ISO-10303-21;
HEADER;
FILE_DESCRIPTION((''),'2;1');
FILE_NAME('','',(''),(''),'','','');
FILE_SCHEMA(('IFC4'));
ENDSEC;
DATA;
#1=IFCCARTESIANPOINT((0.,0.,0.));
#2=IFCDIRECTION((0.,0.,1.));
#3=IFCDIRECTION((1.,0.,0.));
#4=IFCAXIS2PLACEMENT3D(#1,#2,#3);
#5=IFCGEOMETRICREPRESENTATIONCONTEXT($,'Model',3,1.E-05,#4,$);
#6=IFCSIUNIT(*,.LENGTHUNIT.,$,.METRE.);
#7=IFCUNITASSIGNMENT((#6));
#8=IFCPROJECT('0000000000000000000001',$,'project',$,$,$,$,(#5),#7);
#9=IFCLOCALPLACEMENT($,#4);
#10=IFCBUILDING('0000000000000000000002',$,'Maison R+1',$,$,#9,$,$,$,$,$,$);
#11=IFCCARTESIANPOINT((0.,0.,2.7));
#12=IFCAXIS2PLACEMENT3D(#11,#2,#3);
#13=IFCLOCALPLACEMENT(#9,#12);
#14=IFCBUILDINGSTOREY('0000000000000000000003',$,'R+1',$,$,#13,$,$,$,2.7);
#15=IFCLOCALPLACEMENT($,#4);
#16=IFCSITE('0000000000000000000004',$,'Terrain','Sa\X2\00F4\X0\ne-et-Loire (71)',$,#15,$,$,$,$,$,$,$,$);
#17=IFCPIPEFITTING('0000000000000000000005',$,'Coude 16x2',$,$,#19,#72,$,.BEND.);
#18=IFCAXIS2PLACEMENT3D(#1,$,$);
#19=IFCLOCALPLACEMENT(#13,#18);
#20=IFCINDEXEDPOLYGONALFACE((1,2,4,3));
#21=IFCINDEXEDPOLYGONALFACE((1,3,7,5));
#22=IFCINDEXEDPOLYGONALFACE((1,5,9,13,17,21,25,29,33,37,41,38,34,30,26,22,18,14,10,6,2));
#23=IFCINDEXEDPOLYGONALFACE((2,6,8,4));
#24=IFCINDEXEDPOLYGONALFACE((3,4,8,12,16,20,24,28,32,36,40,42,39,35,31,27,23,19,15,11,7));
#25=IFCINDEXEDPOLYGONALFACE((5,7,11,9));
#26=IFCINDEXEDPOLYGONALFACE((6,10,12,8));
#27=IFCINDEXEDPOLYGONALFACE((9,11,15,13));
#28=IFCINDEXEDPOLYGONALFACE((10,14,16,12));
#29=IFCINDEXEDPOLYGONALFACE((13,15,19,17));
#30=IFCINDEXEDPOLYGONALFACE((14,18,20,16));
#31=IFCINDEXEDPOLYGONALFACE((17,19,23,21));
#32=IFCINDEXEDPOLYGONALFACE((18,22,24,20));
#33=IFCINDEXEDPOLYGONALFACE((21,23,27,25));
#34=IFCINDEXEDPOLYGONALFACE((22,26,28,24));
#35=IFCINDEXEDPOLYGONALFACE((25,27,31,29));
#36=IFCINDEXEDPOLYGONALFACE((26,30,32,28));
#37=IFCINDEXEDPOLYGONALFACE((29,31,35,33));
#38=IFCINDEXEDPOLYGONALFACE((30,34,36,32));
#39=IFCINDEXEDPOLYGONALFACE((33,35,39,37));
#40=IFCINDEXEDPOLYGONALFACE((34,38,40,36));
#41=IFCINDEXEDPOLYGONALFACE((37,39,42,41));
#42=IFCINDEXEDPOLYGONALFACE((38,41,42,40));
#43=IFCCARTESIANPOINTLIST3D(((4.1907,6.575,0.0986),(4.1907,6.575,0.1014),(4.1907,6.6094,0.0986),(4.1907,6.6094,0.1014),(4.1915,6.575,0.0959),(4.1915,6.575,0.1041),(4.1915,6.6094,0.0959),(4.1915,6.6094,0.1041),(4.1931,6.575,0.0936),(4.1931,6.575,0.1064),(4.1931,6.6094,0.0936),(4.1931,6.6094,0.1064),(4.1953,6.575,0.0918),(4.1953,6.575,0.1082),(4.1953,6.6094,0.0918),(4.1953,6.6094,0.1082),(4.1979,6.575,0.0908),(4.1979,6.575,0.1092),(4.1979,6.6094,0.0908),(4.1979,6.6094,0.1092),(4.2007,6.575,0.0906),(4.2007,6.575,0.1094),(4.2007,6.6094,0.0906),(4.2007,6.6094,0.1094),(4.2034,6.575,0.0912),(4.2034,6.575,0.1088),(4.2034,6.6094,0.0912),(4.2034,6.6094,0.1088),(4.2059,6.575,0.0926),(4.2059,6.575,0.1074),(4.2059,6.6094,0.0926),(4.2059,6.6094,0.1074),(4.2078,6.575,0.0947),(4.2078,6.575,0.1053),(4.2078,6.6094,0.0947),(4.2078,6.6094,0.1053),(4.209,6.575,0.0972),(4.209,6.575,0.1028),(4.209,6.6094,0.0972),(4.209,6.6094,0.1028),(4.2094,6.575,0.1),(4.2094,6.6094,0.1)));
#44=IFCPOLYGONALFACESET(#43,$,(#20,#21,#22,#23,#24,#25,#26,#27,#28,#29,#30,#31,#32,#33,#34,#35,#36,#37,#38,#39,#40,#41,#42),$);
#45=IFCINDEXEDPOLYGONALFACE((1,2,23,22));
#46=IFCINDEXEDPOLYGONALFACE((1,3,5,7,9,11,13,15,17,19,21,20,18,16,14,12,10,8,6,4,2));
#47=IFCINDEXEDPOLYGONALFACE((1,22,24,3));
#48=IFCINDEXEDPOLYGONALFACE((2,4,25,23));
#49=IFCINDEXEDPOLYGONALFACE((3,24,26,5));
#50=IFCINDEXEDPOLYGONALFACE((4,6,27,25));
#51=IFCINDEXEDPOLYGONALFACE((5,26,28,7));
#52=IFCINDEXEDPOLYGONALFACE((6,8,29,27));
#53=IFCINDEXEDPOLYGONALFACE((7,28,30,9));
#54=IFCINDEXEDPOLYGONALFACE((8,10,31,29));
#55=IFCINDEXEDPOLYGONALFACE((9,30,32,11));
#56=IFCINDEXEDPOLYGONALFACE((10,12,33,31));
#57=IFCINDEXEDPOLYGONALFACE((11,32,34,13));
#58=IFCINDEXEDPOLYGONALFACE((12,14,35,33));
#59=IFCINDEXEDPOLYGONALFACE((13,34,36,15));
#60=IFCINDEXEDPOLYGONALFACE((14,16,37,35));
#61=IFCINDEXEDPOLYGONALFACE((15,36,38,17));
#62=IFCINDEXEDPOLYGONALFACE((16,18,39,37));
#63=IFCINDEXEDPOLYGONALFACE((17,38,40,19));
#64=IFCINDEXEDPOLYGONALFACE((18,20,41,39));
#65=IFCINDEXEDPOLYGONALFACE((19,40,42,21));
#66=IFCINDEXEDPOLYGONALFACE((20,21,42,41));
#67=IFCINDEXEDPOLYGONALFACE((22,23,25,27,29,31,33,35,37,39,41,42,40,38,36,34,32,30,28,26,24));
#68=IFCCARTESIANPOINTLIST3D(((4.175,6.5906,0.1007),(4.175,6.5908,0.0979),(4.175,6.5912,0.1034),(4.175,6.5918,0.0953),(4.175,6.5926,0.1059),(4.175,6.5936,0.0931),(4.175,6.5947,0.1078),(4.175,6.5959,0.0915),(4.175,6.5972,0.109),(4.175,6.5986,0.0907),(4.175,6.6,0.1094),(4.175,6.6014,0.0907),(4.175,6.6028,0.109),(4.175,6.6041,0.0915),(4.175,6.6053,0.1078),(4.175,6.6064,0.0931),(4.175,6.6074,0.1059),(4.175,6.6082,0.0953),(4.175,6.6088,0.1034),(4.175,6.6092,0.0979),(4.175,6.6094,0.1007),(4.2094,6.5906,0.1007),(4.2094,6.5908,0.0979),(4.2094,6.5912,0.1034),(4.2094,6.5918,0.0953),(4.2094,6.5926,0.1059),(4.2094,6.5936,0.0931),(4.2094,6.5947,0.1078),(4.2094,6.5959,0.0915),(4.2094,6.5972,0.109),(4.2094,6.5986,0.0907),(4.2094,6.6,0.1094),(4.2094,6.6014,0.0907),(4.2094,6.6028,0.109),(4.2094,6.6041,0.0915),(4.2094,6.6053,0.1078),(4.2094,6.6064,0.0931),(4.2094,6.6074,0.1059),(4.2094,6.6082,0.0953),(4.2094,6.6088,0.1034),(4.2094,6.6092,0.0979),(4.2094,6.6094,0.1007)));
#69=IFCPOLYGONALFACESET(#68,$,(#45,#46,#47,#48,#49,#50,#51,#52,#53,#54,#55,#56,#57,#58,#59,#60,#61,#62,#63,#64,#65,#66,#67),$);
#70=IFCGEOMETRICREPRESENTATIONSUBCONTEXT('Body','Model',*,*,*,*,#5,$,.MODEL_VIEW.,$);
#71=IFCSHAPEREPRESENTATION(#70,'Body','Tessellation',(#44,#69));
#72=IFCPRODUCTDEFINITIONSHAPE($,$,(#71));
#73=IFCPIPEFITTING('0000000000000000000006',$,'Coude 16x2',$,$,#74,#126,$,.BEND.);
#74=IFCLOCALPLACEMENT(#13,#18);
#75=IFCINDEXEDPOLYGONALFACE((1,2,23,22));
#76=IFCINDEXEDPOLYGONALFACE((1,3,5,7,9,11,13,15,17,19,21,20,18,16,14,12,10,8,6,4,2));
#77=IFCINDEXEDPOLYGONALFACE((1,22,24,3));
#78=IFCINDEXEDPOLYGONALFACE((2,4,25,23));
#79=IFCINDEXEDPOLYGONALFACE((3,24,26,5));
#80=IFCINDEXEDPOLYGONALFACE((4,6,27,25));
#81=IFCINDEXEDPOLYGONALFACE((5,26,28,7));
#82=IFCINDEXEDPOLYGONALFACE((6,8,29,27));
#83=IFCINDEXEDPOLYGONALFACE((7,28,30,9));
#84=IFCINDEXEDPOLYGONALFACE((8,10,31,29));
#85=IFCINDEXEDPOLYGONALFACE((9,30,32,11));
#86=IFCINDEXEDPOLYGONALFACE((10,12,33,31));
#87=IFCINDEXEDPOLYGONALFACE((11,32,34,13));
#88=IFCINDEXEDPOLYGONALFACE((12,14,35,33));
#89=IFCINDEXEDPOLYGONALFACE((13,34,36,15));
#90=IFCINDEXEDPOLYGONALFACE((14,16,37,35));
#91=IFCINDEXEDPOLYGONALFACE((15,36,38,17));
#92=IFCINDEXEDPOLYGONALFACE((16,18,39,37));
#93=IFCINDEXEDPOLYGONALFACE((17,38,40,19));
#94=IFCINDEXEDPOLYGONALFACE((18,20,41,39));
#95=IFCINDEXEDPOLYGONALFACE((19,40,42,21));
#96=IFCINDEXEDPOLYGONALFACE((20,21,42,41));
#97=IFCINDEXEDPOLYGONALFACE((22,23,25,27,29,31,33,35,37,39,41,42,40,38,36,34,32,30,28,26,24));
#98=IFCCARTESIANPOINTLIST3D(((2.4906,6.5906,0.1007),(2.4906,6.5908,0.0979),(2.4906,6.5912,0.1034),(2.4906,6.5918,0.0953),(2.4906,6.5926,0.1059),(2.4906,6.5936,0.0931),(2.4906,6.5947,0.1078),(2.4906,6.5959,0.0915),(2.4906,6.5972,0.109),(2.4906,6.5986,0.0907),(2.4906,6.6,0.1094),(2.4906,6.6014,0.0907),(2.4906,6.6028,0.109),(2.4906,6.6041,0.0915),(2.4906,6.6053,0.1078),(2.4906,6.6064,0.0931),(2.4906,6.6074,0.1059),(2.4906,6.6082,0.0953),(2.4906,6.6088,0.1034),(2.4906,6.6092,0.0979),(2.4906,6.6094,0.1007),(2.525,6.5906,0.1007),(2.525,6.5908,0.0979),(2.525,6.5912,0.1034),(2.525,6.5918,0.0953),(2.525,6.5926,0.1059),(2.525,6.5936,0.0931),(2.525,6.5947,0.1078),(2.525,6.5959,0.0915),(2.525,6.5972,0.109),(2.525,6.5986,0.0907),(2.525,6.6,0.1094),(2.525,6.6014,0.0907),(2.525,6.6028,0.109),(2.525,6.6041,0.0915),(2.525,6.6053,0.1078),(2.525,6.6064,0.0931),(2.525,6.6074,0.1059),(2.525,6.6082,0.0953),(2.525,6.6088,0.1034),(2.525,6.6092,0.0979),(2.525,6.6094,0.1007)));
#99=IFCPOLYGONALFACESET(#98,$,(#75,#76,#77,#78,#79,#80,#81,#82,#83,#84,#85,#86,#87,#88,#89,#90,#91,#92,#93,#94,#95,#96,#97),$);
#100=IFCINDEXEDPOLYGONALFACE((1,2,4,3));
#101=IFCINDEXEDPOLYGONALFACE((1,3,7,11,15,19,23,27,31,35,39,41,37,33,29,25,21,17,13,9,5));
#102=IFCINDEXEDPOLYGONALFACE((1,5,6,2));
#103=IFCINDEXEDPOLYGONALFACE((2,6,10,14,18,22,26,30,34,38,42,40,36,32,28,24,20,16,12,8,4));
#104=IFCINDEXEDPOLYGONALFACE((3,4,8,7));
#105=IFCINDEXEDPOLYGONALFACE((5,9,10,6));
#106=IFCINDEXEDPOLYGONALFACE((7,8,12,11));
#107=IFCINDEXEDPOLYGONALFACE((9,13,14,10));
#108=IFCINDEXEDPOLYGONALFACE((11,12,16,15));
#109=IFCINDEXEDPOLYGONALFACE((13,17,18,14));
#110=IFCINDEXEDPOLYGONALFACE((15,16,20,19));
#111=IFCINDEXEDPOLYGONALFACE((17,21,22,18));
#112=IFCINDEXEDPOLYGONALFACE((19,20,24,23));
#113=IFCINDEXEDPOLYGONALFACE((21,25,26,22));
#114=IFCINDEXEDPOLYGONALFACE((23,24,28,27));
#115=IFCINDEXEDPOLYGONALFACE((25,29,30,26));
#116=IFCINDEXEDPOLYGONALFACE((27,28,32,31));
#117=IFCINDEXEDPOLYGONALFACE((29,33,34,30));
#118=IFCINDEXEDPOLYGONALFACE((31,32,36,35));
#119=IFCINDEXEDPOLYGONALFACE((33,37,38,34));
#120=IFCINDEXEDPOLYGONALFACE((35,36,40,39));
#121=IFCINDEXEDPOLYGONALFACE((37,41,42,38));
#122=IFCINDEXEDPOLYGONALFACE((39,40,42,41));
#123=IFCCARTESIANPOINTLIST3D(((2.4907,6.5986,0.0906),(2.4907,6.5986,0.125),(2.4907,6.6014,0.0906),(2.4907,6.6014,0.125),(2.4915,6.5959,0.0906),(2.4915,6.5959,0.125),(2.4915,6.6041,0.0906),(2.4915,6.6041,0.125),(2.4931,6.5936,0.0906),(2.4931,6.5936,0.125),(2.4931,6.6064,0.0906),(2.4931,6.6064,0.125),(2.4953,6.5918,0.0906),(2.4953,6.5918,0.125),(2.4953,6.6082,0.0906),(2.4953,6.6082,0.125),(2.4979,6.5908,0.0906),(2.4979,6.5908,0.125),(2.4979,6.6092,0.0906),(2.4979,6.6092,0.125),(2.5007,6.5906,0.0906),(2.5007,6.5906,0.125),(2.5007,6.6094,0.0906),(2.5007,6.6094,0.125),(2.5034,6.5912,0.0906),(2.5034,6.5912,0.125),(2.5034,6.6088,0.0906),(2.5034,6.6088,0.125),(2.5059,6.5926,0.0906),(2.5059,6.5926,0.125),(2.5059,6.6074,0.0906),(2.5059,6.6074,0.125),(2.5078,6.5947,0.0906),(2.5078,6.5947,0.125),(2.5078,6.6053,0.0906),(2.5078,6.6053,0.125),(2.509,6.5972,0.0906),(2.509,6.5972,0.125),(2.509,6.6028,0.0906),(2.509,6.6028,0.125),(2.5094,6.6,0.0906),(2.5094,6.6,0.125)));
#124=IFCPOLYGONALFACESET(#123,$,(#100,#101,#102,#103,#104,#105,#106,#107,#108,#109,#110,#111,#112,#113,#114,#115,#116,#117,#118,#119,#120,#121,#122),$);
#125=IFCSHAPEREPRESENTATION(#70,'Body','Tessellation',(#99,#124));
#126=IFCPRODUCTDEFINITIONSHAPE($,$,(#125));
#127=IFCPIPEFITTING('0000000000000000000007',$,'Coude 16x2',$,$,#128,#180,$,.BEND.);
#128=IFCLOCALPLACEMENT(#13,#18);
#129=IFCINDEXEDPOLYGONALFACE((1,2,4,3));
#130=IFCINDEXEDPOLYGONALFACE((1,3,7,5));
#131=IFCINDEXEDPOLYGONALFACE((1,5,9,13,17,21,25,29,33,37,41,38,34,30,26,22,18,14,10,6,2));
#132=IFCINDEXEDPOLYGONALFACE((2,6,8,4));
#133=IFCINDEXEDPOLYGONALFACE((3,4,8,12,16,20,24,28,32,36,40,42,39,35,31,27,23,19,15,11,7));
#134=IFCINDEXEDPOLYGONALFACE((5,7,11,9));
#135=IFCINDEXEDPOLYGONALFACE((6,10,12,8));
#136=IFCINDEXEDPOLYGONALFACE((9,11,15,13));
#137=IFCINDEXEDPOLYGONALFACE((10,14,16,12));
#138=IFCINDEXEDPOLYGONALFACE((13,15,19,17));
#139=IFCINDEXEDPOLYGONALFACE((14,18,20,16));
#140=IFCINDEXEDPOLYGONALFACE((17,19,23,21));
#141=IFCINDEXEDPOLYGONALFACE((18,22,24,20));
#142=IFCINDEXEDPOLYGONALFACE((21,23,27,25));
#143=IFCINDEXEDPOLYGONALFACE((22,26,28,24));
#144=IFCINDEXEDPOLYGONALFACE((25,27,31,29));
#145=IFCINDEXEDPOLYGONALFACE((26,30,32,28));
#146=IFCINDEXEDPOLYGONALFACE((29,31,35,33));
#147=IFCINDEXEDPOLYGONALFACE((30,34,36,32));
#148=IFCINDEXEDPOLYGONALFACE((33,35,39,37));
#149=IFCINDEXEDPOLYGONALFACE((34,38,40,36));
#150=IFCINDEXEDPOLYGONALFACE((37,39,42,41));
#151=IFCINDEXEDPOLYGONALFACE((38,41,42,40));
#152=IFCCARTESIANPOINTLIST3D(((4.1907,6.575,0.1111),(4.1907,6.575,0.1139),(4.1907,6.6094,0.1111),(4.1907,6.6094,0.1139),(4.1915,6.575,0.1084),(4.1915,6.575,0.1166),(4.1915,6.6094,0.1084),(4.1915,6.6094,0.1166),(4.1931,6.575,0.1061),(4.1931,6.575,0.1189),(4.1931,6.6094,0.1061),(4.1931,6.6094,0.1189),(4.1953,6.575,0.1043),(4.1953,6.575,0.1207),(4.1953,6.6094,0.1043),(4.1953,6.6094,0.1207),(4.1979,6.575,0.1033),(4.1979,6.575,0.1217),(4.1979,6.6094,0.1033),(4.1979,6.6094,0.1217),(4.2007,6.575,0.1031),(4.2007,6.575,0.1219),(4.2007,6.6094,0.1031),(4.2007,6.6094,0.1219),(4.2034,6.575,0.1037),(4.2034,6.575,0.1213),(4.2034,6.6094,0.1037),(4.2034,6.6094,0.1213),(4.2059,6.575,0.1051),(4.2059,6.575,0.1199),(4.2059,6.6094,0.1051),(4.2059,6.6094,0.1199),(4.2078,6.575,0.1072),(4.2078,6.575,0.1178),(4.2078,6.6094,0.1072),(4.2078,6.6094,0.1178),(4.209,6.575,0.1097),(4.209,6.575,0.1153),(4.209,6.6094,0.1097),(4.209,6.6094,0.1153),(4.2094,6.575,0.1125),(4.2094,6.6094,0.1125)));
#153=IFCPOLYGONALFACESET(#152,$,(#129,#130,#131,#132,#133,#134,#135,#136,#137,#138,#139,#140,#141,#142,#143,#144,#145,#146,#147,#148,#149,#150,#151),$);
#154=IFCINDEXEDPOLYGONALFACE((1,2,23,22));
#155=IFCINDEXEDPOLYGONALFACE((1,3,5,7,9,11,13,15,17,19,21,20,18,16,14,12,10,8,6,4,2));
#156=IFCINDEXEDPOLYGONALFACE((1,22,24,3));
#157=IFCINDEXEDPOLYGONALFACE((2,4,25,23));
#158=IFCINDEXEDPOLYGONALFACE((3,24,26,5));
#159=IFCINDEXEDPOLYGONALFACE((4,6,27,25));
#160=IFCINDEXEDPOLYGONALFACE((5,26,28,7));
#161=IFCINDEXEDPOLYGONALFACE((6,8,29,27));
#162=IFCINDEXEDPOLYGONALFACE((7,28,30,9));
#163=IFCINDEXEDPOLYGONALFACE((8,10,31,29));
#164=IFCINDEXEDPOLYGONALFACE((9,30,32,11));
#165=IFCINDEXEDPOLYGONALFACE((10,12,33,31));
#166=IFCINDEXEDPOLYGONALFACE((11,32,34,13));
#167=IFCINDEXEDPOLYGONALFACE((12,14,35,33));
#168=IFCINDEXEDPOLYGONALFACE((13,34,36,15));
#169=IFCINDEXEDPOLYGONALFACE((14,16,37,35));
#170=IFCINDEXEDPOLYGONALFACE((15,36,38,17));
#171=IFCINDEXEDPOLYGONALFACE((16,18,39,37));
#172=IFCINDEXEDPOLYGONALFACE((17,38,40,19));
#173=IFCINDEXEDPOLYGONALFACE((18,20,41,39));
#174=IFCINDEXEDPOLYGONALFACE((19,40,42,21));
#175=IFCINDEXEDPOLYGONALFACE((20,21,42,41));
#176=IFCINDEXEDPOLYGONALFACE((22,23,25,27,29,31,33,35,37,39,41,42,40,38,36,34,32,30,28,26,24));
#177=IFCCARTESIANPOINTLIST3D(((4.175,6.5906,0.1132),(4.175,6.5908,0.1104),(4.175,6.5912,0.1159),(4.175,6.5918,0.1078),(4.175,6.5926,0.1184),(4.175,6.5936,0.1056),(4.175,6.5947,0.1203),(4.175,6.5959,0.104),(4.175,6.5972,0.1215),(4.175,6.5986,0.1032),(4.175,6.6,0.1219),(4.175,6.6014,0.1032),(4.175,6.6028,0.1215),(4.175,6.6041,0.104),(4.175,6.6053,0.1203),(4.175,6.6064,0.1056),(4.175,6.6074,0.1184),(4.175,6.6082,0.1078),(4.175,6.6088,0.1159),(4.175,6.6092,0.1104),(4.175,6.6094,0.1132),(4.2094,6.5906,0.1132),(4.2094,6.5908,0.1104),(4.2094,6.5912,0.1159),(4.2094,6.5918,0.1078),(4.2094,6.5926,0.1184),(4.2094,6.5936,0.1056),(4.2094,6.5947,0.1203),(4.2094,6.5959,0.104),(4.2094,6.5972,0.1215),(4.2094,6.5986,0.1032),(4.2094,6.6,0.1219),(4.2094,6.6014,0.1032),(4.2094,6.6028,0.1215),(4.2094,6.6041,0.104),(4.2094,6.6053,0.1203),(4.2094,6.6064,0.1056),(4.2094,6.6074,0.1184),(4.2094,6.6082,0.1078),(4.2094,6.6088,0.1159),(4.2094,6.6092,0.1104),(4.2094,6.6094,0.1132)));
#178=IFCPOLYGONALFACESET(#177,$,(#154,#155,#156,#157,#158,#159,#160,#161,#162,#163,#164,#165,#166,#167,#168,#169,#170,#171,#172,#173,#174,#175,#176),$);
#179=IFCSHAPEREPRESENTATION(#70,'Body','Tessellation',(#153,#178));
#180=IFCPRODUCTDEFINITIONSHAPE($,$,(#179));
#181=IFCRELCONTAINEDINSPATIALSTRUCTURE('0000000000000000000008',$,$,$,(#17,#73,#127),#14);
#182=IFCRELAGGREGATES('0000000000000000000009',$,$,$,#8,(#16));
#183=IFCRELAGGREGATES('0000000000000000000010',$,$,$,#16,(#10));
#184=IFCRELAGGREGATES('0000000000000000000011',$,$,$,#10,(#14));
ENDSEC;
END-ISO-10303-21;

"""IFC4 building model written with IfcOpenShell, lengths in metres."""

from ifc_helpers import new_model, si_unit, frame, origin_with_axes, place, context, subcontext, project, spatial, circle, extrude, element, save


model = new_model("IFC4")

# Units and contexts
model_context = context("Model", 3, precision=1e-05, world=origin_with_axes())
body_context = subcontext(model_context, "Body", "Model", "MODEL_VIEW")
ifc_project = project(units=[si_unit("LENGTHUNIT", "METRE")], contexts=[model_context])

# Site, building, storey
site_placement = place(None, origin_with_axes())
site = spatial("IfcSite", under=ifc_project, at=site_placement, Name="Terrain", Description="Saône-et-Loire (71)")
building_placement = place(None, origin_with_axes())
building = spatial("IfcBuilding", under=site, at=building_placement, Name="Maison R+1")
storey_placement = place(building_placement, frame((0.0, 0.0, 2.7), z_axis=(0.0, 0.0, 1.0), x_axis=(1.0, 0.0, 0.0)))
storey = spatial("IfcBuildingStorey", under=building, at=storey_placement, Name="R+1", Elevation=2.7)

# Pipe fittings
pipe_fitting_1_placement = place(storey_placement, frame((4.2, 6.6, 0.1), z_axis=(0.0, 0.0, 1.0), x_axis=(1.0, 0.0, 0.0)))
element("IfcPipeFitting", 1, at=pipe_fitting_1_placement, inside=storey, Name="Coude 16x2", PredefinedType="BEND", context=body_context, shape_type="SweptSolid", body=[
    extrude(circle(Radius=0.0094), frame((0.0, 0.0094, 0.0), z_axis=(0.0, -1.0, 0.0), x_axis=(1.0, 0.0, 0.0)), (0.0, 0.0, 1.0), 0.0344),
    extrude(circle(Radius=0.0094), frame((0.0094, 0.0, 0.0), z_axis=(-1.0, 0.0, 0.0), x_axis=(0.0, 0.0, 1.0)), (0.0, 0.0, 1.0), 0.0344),
])
pipe_fitting_2_placement = place(storey_placement, frame((2.5, 6.6, 0.1), z_axis=(0.0, 0.0, 1.0), x_axis=(1.0, 0.0, 0.0)))
element("IfcPipeFitting", 2, at=pipe_fitting_2_placement, inside=storey, Name="Coude 16x2", PredefinedType="BEND", context=body_context, shape_type="SweptSolid", body=[
    extrude(circle(Radius=0.0094), frame((-0.0094, 0.0, 0.0), z_axis=(1.0, 0.0, 0.0), x_axis=(0.0, 0.0, 1.0)), (0.0, 0.0, 1.0), 0.0344),
    extrude(circle(Radius=0.0094), frame((0.0, 0.0, -0.0094), z_axis=(0.0, 0.0, 1.0), x_axis=(1.0, 0.0, 0.0)), (0.0, 0.0, 1.0), 0.0344),
])
pipe_fitting_3_placement = place(storey_placement, frame((4.2, 6.6, 0.1125), z_axis=(0.0, 0.0, 1.0), x_axis=(1.0, 0.0, 0.0)))
element("IfcPipeFitting", 3, at=pipe_fitting_3_placement, inside=storey, Name="Coude 16x2", PredefinedType="BEND", context=body_context, shape_type="SweptSolid", body=[
    extrude(circle(Radius=0.0094), frame((0.0, 0.0094, 0.0), z_axis=(0.0, -1.0, 0.0), x_axis=(1.0, 0.0, 0.0)), (0.0, 0.0, 1.0), 0.0344),
    extrude(circle(Radius=0.0094), frame((0.0094, 0.0, 0.0), z_axis=(-1.0, 0.0, 0.0), x_axis=(0.0, 0.0, 1.0)), (0.0, 0.0, 1.0), 0.0344),
])

save(model, "model.ifc")
